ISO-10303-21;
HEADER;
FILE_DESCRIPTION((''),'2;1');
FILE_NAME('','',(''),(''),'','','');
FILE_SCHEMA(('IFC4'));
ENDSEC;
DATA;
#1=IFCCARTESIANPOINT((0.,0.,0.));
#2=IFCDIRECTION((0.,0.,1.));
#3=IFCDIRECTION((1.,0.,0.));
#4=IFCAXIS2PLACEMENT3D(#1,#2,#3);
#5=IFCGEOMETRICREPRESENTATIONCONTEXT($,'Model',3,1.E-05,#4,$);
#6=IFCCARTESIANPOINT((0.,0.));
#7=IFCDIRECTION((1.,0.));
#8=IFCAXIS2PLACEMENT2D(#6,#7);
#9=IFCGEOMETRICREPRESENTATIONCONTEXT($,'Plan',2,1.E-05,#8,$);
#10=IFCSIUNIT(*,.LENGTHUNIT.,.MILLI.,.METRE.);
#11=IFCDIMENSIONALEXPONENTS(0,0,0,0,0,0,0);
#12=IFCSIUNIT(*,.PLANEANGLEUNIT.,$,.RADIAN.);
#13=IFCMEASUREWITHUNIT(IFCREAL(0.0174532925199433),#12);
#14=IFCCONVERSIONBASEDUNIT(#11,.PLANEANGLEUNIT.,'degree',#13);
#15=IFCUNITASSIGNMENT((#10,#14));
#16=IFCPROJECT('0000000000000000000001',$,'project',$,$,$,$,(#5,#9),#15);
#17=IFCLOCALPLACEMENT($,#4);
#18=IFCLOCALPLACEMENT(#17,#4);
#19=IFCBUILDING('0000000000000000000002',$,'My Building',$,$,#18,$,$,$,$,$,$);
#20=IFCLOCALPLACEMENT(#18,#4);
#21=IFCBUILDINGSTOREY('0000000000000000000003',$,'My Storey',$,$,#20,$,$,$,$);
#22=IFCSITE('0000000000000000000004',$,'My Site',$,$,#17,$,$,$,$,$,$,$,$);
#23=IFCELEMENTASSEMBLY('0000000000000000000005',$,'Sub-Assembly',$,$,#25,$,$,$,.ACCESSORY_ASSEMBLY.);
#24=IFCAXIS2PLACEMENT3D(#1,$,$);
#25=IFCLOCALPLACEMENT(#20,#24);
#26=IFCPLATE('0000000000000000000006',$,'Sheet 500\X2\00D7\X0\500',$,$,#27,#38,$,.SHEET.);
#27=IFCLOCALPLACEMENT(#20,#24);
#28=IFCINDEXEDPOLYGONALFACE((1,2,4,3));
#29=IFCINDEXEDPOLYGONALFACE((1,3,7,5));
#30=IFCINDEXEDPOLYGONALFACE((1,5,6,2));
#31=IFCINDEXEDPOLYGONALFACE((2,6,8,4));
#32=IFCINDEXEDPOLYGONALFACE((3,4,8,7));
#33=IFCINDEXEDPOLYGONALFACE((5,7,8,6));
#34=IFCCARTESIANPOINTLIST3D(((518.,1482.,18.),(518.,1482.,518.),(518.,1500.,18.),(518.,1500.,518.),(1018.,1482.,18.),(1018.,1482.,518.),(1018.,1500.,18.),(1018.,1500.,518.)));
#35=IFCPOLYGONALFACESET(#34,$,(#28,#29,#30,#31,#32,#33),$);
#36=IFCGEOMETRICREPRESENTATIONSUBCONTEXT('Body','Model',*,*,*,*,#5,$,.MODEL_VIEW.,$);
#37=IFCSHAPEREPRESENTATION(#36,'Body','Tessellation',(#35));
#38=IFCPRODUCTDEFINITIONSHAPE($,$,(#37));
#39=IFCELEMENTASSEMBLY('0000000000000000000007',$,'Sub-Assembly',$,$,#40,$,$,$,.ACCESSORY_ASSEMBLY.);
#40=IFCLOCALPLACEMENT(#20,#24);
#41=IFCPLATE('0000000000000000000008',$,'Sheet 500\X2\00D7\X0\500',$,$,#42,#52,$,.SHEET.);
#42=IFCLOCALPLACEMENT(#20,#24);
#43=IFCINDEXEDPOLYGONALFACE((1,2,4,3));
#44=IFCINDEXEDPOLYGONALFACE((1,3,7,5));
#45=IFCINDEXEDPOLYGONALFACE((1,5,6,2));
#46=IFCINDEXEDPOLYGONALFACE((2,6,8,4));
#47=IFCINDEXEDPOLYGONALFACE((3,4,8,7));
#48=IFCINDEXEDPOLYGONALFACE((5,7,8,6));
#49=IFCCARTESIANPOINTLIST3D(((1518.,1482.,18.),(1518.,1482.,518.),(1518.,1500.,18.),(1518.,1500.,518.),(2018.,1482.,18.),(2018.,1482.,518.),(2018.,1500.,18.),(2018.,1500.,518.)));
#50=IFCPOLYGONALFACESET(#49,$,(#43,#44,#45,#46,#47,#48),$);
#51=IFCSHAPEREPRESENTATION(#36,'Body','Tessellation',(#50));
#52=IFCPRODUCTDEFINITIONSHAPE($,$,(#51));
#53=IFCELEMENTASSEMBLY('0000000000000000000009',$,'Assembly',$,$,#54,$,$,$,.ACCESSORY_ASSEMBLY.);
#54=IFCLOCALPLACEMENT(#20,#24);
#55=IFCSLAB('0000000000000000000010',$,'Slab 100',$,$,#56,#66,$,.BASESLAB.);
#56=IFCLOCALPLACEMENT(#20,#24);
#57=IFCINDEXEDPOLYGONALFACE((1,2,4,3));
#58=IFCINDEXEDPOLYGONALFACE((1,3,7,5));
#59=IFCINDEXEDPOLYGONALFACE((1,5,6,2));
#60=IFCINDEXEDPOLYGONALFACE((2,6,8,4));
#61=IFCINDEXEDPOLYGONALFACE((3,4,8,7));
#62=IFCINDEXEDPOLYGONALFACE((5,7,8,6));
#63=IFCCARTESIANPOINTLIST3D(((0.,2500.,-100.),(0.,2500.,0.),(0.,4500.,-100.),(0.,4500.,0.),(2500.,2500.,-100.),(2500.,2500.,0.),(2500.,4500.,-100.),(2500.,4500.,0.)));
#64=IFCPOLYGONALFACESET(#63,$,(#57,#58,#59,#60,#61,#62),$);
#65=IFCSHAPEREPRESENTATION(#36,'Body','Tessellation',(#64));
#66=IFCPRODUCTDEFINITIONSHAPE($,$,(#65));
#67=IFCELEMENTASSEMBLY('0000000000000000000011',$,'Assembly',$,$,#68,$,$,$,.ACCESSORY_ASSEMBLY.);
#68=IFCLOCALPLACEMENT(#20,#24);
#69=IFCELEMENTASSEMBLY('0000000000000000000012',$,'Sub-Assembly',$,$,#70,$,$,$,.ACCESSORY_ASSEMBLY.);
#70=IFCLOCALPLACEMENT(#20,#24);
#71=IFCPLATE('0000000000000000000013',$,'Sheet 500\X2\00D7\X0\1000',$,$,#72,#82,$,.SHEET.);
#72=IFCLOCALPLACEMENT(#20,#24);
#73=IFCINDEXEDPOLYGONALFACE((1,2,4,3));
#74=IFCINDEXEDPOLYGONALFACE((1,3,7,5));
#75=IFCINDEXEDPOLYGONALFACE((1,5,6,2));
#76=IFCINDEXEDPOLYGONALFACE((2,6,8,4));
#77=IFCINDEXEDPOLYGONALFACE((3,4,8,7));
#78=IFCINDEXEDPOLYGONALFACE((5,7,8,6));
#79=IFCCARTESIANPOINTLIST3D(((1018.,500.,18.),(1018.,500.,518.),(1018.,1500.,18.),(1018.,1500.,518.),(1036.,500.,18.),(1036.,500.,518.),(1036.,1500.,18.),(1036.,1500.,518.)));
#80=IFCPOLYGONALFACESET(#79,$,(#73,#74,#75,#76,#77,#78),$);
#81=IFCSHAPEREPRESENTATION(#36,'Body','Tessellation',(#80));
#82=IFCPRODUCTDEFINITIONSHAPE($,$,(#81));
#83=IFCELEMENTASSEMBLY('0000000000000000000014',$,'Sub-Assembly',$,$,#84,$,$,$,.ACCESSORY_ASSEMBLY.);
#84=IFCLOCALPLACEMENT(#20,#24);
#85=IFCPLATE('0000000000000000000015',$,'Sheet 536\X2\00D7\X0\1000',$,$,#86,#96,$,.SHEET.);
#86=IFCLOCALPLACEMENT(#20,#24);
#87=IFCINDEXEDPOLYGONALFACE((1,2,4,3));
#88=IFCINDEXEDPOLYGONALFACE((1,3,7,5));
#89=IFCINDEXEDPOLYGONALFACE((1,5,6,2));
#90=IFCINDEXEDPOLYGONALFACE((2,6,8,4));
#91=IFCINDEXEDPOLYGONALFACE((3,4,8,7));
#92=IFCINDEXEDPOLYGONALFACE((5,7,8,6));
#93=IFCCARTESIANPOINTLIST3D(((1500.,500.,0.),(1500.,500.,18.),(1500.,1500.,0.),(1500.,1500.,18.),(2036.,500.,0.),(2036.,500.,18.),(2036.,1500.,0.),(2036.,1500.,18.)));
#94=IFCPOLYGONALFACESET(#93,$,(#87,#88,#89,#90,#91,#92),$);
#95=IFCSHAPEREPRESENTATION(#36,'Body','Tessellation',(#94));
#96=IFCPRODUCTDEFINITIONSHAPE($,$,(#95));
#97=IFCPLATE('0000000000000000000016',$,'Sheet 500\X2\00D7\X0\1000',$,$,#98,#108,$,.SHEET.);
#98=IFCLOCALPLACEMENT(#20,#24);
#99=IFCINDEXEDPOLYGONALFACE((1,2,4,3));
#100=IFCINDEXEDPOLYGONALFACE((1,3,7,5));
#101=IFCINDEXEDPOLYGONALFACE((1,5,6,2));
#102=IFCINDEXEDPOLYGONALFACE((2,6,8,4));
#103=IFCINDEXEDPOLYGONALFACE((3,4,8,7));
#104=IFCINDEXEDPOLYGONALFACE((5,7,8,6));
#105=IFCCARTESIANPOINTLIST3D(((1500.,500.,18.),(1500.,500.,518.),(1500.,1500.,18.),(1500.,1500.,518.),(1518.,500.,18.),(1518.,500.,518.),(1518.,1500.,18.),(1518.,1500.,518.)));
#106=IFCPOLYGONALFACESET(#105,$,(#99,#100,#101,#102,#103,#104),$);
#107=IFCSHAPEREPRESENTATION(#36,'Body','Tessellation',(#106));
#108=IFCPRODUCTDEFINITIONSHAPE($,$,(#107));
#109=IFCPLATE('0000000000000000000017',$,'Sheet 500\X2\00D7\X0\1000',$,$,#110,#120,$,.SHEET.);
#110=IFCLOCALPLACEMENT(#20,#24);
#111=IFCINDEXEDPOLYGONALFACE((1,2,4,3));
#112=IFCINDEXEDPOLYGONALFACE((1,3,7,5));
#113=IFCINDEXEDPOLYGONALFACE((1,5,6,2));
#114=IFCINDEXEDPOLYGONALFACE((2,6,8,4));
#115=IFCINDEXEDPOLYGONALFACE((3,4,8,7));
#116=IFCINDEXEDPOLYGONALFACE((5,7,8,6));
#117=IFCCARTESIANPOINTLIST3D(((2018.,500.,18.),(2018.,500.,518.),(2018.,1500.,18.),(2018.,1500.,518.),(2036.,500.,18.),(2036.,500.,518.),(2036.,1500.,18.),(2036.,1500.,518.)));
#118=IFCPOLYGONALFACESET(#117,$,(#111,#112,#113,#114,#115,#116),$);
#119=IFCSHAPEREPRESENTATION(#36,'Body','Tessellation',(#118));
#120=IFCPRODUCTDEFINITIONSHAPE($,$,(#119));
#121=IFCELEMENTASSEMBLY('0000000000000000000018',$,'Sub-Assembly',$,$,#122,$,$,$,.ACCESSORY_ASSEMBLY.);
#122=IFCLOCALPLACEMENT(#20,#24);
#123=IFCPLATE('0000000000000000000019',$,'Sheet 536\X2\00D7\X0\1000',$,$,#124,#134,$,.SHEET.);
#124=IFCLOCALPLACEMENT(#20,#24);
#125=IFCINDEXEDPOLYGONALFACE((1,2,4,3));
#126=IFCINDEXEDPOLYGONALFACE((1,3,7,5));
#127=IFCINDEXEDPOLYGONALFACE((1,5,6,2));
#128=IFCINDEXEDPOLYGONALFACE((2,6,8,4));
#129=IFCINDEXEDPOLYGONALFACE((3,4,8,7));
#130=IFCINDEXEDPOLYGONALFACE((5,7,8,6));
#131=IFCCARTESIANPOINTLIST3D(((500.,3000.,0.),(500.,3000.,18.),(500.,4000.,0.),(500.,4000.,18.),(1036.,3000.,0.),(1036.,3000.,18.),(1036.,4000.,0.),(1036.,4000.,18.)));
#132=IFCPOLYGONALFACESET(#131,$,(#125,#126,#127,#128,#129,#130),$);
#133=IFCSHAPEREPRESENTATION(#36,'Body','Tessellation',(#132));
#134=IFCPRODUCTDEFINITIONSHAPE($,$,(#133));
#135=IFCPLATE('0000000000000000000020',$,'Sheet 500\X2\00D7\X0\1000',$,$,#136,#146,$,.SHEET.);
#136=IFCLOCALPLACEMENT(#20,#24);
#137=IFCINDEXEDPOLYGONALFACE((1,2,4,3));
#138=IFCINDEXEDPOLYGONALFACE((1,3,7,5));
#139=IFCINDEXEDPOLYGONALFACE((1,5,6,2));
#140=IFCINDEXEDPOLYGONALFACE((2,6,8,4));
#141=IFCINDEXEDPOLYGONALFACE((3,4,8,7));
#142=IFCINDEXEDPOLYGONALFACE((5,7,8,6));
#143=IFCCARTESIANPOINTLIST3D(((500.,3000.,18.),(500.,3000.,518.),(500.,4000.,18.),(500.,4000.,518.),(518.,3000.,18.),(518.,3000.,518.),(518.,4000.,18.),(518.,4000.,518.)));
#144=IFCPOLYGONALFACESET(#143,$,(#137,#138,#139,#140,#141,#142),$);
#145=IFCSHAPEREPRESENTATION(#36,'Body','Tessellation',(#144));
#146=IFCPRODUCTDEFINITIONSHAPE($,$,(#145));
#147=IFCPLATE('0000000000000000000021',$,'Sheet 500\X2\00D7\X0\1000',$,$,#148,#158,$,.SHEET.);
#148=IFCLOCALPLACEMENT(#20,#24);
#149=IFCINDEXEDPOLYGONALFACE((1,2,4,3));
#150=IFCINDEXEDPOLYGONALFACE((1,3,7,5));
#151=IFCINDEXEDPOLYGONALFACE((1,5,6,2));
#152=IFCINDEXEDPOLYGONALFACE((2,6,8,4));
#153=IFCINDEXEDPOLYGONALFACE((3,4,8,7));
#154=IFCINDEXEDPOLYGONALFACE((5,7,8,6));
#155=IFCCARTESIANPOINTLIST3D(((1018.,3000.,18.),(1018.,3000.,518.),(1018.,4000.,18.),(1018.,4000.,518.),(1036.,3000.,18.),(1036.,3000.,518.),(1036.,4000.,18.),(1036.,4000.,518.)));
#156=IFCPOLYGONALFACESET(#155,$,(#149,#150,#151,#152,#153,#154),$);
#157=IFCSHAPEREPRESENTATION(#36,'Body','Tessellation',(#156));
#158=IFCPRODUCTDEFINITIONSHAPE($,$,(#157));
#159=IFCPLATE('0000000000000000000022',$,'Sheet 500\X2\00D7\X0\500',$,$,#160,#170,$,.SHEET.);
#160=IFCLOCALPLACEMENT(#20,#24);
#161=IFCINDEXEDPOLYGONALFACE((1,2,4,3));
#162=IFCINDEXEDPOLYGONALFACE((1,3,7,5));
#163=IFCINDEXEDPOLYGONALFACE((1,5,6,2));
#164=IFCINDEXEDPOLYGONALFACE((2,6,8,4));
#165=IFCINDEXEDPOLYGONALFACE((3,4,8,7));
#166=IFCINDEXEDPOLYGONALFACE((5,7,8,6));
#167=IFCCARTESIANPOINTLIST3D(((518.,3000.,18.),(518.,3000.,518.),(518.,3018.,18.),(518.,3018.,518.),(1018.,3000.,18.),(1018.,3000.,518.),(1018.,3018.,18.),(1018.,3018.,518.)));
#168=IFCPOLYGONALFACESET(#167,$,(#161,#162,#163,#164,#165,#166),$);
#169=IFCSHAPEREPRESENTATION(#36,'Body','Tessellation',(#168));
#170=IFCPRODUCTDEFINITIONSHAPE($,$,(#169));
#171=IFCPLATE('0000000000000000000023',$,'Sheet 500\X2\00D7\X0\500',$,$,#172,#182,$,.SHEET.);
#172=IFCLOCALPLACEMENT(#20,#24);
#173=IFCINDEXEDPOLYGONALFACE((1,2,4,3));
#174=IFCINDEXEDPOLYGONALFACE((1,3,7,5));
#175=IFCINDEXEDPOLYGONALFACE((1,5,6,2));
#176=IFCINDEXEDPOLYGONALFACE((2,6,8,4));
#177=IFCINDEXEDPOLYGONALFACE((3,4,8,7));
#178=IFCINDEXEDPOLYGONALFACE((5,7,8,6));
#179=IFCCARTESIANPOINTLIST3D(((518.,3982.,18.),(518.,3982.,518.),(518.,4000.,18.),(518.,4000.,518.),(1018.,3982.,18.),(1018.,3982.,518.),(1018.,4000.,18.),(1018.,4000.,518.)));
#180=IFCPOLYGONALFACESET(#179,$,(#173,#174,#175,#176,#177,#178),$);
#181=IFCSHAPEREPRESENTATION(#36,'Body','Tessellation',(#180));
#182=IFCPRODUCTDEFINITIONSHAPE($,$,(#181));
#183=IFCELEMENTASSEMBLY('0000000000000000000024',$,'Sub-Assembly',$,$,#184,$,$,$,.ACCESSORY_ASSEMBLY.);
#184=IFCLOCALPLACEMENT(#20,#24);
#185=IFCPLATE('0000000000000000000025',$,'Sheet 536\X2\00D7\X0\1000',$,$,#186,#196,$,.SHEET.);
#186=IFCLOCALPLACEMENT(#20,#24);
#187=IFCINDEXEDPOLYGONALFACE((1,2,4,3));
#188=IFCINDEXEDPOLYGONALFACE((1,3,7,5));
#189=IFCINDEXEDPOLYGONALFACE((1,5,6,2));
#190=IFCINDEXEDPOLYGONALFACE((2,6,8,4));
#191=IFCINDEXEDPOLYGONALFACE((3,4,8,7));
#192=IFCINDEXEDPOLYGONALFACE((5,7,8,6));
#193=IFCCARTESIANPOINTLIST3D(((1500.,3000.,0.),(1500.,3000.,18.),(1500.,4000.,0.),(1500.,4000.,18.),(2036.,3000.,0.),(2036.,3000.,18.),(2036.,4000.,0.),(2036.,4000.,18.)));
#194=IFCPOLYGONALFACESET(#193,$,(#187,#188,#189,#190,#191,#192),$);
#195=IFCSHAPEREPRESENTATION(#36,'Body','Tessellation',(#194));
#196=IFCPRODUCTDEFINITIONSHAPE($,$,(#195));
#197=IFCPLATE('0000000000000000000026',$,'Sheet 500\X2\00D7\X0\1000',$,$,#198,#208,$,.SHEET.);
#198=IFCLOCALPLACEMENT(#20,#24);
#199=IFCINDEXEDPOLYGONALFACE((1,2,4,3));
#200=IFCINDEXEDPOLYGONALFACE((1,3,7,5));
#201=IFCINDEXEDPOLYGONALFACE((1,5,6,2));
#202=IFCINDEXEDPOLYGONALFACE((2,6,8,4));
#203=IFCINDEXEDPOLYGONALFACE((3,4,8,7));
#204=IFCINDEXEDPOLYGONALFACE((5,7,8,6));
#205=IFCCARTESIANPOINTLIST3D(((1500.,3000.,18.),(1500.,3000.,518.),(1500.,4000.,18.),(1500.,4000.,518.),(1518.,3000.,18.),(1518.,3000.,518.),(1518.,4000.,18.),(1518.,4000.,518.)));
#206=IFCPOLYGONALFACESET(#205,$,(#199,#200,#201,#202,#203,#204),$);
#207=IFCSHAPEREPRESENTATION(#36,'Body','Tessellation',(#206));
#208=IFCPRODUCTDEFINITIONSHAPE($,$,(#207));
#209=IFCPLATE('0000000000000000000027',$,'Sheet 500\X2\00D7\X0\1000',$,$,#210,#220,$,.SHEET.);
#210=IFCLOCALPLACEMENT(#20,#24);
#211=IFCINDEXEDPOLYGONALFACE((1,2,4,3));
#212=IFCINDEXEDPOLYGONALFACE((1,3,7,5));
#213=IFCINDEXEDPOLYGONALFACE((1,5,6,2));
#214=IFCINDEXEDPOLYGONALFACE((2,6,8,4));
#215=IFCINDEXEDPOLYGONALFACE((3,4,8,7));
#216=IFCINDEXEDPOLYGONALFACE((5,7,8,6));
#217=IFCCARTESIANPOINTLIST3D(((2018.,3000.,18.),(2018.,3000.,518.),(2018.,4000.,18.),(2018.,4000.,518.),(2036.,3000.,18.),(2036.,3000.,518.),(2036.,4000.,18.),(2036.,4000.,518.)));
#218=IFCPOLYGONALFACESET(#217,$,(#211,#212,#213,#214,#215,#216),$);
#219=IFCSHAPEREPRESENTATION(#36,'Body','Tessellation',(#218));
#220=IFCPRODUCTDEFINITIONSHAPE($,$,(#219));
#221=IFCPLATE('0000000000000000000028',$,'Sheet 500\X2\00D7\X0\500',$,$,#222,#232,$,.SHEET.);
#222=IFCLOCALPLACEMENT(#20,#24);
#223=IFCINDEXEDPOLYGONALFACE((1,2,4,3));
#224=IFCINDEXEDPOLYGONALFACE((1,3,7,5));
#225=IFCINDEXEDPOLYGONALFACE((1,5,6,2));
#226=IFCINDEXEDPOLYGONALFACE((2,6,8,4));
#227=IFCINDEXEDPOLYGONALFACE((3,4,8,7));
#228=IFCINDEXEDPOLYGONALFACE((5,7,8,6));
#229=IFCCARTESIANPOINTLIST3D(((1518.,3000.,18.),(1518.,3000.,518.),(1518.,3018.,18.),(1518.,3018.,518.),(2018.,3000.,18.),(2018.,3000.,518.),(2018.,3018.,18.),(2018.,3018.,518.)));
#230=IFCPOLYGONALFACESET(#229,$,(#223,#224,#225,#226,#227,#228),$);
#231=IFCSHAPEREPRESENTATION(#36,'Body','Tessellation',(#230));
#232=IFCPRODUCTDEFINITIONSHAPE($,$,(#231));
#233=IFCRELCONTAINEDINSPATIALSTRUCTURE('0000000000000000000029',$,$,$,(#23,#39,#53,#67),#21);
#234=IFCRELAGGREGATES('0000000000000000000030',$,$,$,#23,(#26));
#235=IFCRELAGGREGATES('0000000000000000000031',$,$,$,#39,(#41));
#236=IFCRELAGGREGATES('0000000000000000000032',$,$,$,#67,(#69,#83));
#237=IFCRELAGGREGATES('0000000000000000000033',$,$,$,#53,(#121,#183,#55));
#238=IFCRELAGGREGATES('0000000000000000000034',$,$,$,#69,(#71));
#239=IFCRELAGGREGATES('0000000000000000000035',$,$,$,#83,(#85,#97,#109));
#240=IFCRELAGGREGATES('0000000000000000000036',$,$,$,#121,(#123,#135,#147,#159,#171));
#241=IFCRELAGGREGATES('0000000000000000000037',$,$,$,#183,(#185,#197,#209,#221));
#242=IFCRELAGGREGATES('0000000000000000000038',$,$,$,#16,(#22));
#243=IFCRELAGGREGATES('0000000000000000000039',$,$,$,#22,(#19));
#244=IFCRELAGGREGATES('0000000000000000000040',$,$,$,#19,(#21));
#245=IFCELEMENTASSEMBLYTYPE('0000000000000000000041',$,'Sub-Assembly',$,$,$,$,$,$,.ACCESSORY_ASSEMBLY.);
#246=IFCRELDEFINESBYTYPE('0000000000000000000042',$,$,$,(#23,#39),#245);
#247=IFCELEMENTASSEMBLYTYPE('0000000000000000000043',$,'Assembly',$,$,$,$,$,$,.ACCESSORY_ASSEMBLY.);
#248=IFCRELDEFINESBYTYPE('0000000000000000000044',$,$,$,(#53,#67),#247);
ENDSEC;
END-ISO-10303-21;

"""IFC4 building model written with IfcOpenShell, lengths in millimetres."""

from ifc_helpers import new_model, entity, si_unit, converted_unit, frame, origin_with_axes, origin_2d_with_axis, place, context, subcontext, project, spatial, rectangle, extrude, type_object, element, aggregate, save


model = new_model("IFC4")

# Units and contexts
model_context = context("Model", 3, precision=1e-05, world=origin_with_axes())
plan_context = context("Plan", 2, precision=1e-05, world=origin_2d_with_axis())
body_context = subcontext(model_context, "Body", "Model", "MODEL_VIEW")
ifc_project = project(units=[si_unit("LENGTHUNIT", "METRE", prefix="MILLI"), converted_unit("PLANEANGLEUNIT", "degree", entity("IfcReal", 0.0174532925199433), si_unit("PLANEANGLEUNIT", "RADIAN"), dimensions=[0, 0, 0, 0, 0, 0, 0])], contexts=[model_context, plan_context])

# Site, building, storey
site_placement = place(None, origin_with_axes())
site = spatial("IfcSite", under=ifc_project, at=site_placement, Name="My Site")
building_placement = place(site_placement, origin_with_axes())
building = spatial("IfcBuilding", under=site, at=building_placement, Name="My Building")
storey_placement = place(building_placement, origin_with_axes())
storey = spatial("IfcBuildingStorey", under=building, at=storey_placement, Name="My Storey")

# Element assemblies, plates
element_assembly_type_1 = type_object("IfcElementAssemblyType", Name="Sub-Assembly", PredefinedType="ACCESSORY_ASSEMBLY")
assembly_1_placement = place(storey_placement, frame((500.0, 500.0, 0.0)))
assembly_1 = element("IfcElementAssembly", 1, at=assembly_1_placement, inside=storey, type_object=element_assembly_type_1, Name="Sub-Assembly", PredefinedType="ACCESSORY_ASSEMBLY")
plate_1_placement = place(assembly_1_placement, frame((268.0, 982.0, 268.0), z_axis=(0.0, 1.0, 0.0), x_axis=(0.0, 0.0, 1.0)))
plate_1 = element("IfcPlate", 2, at=plate_1_placement, Name="Sheet 500×500", PredefinedType="SHEET", context=body_context, shape_type="SweptSolid", body=[
    extrude(rectangle(XDim=500.0, YDim=500.0), None, (0.0, 0.0, 1.0), 18.0),
])
aggregate(assembly_1, [plate_1])
assembly_2_placement = place(storey_placement, frame((1500.0, 500.0, 0.0)))
assembly_2 = element("IfcElementAssembly", 3, at=assembly_2_placement, inside=storey, type_object=element_assembly_type_1, Name="Sub-Assembly", PredefinedType="ACCESSORY_ASSEMBLY")
plate_2_placement = place(assembly_2_placement, frame((268.0, 982.0, 268.0), z_axis=(0.0, 1.0, 0.0), x_axis=(0.0, 0.0, 1.0)))
plate_2 = element("IfcPlate", 4, at=plate_2_placement, Name="Sheet 500×500", PredefinedType="SHEET", context=body_context, shape_type="SweptSolid", body=[
    extrude(rectangle(XDim=500.0, YDim=500.0), None, (0.0, 0.0, 1.0), 18.0),
])
aggregate(assembly_2, [plate_2])

# Element assembly, slab
element_assembly_type_2 = type_object("IfcElementAssemblyType", Name="Assembly", PredefinedType="ACCESSORY_ASSEMBLY")
assembly_3_placement = place(storey_placement, frame((0.0, 2500.0, 0.0)))
assembly_3 = element("IfcElementAssembly", 5, at=assembly_3_placement, inside=storey, type_object=element_assembly_type_2, Name="Assembly", PredefinedType="ACCESSORY_ASSEMBLY")
slab_placement = place(assembly_3_placement, frame((1250.0, 1000.0, -100.0), z_axis=(0.0, 0.0, 1.0), x_axis=(1.0, 0.0, 0.0)))
slab = element("IfcSlab", 6, at=slab_placement, Name="Slab 100", PredefinedType="BASESLAB", context=body_context, shape_type="SweptSolid", body=[
    extrude(rectangle(XDim=2500.0, YDim=2000.0), None, (0.0, 0.0, 1.0), 100.0),
])

# Element assemblies, plates
assembly_4_placement = place(storey_placement, origin_with_axes())
assembly_4 = element("IfcElementAssembly", 7, at=assembly_4_placement, inside=storey, type_object=element_assembly_type_2, Name="Assembly", PredefinedType="ACCESSORY_ASSEMBLY")
assembly_5_placement = place(assembly_4_placement, frame((500.0, 500.0, 0.0)))
assembly_5 = element("IfcElementAssembly", 8, at=assembly_5_placement, Name="Sub-Assembly", PredefinedType="ACCESSORY_ASSEMBLY")
plate_3_placement = place(assembly_5_placement, frame((518.0, 500.0, 268.0), z_axis=(1.0, 0.0, 0.0), x_axis=(0.0, 0.0, 1.0)))
plate_3 = element("IfcPlate", 9, at=plate_3_placement, Name="Sheet 500×1000", PredefinedType="SHEET", context=body_context, shape_type="SweptSolid", body=[
    extrude(rectangle(XDim=500.0, YDim=1000.0), None, (0.0, 0.0, 1.0), 18.0),
])
assembly_6_placement = place(assembly_4_placement, frame((1500.0, 500.0, 0.0)))
assembly_6 = element("IfcElementAssembly", 10, at=assembly_6_placement, Name="Sub-Assembly", PredefinedType="ACCESSORY_ASSEMBLY")
aggregate(assembly_4, [assembly_5, assembly_6])
plate_4_placement = place(assembly_6_placement, frame((268.0, 500.0, 0.0), z_axis=(0.0, 0.0, 1.0), x_axis=(1.0, 0.0, 0.0)))
plate_4 = element("IfcPlate", 11, at=plate_4_placement, Name="Sheet 536×1000", PredefinedType="SHEET", context=body_context, shape_type="SweptSolid", body=[
    extrude(rectangle(XDim=536.0, YDim=1000.0), None, (0.0, 0.0, 1.0), 18.0),
])
plate_5_placement = place(assembly_6_placement, frame((0.0, 500.0, 268.0), z_axis=(1.0, 0.0, 0.0), x_axis=(0.0, 0.0, 1.0)))
plate_5 = element("IfcPlate", 12, at=plate_5_placement, Name="Sheet 500×1000", PredefinedType="SHEET", context=body_context, shape_type="SweptSolid", body=[
    extrude(rectangle(XDim=500.0, YDim=1000.0), None, (0.0, 0.0, 1.0), 18.0),
])
plate_6_placement = place(assembly_6_placement, frame((518.0, 500.0, 268.0), z_axis=(1.0, 0.0, 0.0), x_axis=(0.0, 0.0, 1.0)))
plate_6 = element("IfcPlate", 13, at=plate_6_placement, Name="Sheet 500×1000", PredefinedType="SHEET", context=body_context, shape_type="SweptSolid", body=[
    extrude(rectangle(XDim=500.0, YDim=1000.0), None, (0.0, 0.0, 1.0), 18.0),
])

# Element assembly, plates
assembly_7_placement = place(assembly_3_placement, frame((500.0, 500.0, 0.0)))
assembly_7 = element("IfcElementAssembly", 14, at=assembly_7_placement, Name="Sub-Assembly", PredefinedType="ACCESSORY_ASSEMBLY")
plate_7_placement = place(assembly_7_placement, frame((268.0, 500.0, 0.0), z_axis=(0.0, 0.0, 1.0), x_axis=(1.0, 0.0, 0.0)))
plate_7 = element("IfcPlate", 15, at=plate_7_placement, Name="Sheet 536×1000", PredefinedType="SHEET", context=body_context, shape_type="SweptSolid", body=[
    extrude(rectangle(XDim=536.0, YDim=1000.0), None, (0.0, 0.0, 1.0), 18.0),
])
plate_8_placement = place(assembly_7_placement, frame((0.0, 500.0, 268.0), z_axis=(1.0, 0.0, 0.0), x_axis=(0.0, 0.0, 1.0)))
plate_8 = element("IfcPlate", 16, at=plate_8_placement, Name="Sheet 500×1000", PredefinedType="SHEET", context=body_context, shape_type="SweptSolid", body=[
    extrude(rectangle(XDim=500.0, YDim=1000.0), None, (0.0, 0.0, 1.0), 18.0),
])
plate_9_placement = place(assembly_7_placement, frame((518.0, 500.0, 268.0), z_axis=(1.0, 0.0, 0.0), x_axis=(0.0, 0.0, 1.0)))
plate_9 = element("IfcPlate", 17, at=plate_9_placement, Name="Sheet 500×1000", PredefinedType="SHEET", context=body_context, shape_type="SweptSolid", body=[
    extrude(rectangle(XDim=500.0, YDim=1000.0), None, (0.0, 0.0, 1.0), 18.0),
])
plate_10_placement = place(assembly_7_placement, frame((268.0, 0.0, 268.0), z_axis=(0.0, 1.0, 0.0), x_axis=(0.0, 0.0, 1.0)))
plate_10 = element("IfcPlate", 18, at=plate_10_placement, Name="Sheet 500×500", PredefinedType="SHEET", context=body_context, shape_type="SweptSolid", body=[
    extrude(rectangle(XDim=500.0, YDim=500.0), None, (0.0, 0.0, 1.0), 18.0),
])
plate_11_placement = place(assembly_7_placement, frame((268.0, 982.0, 268.0), z_axis=(0.0, 1.0, 0.0), x_axis=(0.0, 0.0, 1.0)))
plate_11 = element("IfcPlate", 19, at=plate_11_placement, Name="Sheet 500×500", PredefinedType="SHEET", context=body_context, shape_type="SweptSolid", body=[
    extrude(rectangle(XDim=500.0, YDim=500.0), None, (0.0, 0.0, 1.0), 18.0),
])

# Element assembly
assembly_8_placement = place(assembly_3_placement, frame((1500.0, 500.0, 0.0)))
assembly_8 = element("IfcElementAssembly", 20, at=assembly_8_placement, Name="Sub-Assembly", PredefinedType="ACCESSORY_ASSEMBLY")
aggregate(assembly_3, [assembly_7, assembly_8, slab])

# Plates
plate_12_placement = place(assembly_8_placement, frame((268.0, 500.0, 0.0), z_axis=(0.0, 0.0, 1.0), x_axis=(1.0, 0.0, 0.0)))
plate_12 = element("IfcPlate", 21, at=plate_12_placement, Name="Sheet 536×1000", PredefinedType="SHEET", context=body_context, shape_type="SweptSolid", body=[
    extrude(rectangle(XDim=536.0, YDim=1000.0), None, (0.0, 0.0, 1.0), 18.0),
])
plate_13_placement = place(assembly_8_placement, frame((0.0, 500.0, 268.0), z_axis=(1.0, 0.0, 0.0), x_axis=(0.0, 0.0, 1.0)))
plate_13 = element("IfcPlate", 22, at=plate_13_placement, Name="Sheet 500×1000", PredefinedType="SHEET", context=body_context, shape_type="SweptSolid", body=[
    extrude(rectangle(XDim=500.0, YDim=1000.0), None, (0.0, 0.0, 1.0), 18.0),
])
plate_14_placement = place(assembly_8_placement, frame((518.0, 500.0, 268.0), z_axis=(1.0, 0.0, 0.0), x_axis=(0.0, 0.0, 1.0)))
plate_14 = element("IfcPlate", 23, at=plate_14_placement, Name="Sheet 500×1000", PredefinedType="SHEET", context=body_context, shape_type="SweptSolid", body=[
    extrude(rectangle(XDim=500.0, YDim=1000.0), None, (0.0, 0.0, 1.0), 18.0),
])
plate_15_placement = place(assembly_8_placement, frame((268.0, 0.0, 268.0), z_axis=(0.0, 1.0, 0.0), x_axis=(0.0, 0.0, 1.0)))
plate_15 = element("IfcPlate", 24, at=plate_15_placement, Name="Sheet 500×500", PredefinedType="SHEET", context=body_context, shape_type="SweptSolid", body=[
    extrude(rectangle(XDim=500.0, YDim=500.0), None, (0.0, 0.0, 1.0), 18.0),
])

aggregate(assembly_5, [plate_3])
aggregate(assembly_6, [plate_4, plate_5, plate_6])
aggregate(assembly_7, [plate_7, plate_8, plate_9, plate_10, plate_11])
aggregate(assembly_8, [plate_12, plate_13, plate_14, plate_15])

save(model, "model.ifc")
